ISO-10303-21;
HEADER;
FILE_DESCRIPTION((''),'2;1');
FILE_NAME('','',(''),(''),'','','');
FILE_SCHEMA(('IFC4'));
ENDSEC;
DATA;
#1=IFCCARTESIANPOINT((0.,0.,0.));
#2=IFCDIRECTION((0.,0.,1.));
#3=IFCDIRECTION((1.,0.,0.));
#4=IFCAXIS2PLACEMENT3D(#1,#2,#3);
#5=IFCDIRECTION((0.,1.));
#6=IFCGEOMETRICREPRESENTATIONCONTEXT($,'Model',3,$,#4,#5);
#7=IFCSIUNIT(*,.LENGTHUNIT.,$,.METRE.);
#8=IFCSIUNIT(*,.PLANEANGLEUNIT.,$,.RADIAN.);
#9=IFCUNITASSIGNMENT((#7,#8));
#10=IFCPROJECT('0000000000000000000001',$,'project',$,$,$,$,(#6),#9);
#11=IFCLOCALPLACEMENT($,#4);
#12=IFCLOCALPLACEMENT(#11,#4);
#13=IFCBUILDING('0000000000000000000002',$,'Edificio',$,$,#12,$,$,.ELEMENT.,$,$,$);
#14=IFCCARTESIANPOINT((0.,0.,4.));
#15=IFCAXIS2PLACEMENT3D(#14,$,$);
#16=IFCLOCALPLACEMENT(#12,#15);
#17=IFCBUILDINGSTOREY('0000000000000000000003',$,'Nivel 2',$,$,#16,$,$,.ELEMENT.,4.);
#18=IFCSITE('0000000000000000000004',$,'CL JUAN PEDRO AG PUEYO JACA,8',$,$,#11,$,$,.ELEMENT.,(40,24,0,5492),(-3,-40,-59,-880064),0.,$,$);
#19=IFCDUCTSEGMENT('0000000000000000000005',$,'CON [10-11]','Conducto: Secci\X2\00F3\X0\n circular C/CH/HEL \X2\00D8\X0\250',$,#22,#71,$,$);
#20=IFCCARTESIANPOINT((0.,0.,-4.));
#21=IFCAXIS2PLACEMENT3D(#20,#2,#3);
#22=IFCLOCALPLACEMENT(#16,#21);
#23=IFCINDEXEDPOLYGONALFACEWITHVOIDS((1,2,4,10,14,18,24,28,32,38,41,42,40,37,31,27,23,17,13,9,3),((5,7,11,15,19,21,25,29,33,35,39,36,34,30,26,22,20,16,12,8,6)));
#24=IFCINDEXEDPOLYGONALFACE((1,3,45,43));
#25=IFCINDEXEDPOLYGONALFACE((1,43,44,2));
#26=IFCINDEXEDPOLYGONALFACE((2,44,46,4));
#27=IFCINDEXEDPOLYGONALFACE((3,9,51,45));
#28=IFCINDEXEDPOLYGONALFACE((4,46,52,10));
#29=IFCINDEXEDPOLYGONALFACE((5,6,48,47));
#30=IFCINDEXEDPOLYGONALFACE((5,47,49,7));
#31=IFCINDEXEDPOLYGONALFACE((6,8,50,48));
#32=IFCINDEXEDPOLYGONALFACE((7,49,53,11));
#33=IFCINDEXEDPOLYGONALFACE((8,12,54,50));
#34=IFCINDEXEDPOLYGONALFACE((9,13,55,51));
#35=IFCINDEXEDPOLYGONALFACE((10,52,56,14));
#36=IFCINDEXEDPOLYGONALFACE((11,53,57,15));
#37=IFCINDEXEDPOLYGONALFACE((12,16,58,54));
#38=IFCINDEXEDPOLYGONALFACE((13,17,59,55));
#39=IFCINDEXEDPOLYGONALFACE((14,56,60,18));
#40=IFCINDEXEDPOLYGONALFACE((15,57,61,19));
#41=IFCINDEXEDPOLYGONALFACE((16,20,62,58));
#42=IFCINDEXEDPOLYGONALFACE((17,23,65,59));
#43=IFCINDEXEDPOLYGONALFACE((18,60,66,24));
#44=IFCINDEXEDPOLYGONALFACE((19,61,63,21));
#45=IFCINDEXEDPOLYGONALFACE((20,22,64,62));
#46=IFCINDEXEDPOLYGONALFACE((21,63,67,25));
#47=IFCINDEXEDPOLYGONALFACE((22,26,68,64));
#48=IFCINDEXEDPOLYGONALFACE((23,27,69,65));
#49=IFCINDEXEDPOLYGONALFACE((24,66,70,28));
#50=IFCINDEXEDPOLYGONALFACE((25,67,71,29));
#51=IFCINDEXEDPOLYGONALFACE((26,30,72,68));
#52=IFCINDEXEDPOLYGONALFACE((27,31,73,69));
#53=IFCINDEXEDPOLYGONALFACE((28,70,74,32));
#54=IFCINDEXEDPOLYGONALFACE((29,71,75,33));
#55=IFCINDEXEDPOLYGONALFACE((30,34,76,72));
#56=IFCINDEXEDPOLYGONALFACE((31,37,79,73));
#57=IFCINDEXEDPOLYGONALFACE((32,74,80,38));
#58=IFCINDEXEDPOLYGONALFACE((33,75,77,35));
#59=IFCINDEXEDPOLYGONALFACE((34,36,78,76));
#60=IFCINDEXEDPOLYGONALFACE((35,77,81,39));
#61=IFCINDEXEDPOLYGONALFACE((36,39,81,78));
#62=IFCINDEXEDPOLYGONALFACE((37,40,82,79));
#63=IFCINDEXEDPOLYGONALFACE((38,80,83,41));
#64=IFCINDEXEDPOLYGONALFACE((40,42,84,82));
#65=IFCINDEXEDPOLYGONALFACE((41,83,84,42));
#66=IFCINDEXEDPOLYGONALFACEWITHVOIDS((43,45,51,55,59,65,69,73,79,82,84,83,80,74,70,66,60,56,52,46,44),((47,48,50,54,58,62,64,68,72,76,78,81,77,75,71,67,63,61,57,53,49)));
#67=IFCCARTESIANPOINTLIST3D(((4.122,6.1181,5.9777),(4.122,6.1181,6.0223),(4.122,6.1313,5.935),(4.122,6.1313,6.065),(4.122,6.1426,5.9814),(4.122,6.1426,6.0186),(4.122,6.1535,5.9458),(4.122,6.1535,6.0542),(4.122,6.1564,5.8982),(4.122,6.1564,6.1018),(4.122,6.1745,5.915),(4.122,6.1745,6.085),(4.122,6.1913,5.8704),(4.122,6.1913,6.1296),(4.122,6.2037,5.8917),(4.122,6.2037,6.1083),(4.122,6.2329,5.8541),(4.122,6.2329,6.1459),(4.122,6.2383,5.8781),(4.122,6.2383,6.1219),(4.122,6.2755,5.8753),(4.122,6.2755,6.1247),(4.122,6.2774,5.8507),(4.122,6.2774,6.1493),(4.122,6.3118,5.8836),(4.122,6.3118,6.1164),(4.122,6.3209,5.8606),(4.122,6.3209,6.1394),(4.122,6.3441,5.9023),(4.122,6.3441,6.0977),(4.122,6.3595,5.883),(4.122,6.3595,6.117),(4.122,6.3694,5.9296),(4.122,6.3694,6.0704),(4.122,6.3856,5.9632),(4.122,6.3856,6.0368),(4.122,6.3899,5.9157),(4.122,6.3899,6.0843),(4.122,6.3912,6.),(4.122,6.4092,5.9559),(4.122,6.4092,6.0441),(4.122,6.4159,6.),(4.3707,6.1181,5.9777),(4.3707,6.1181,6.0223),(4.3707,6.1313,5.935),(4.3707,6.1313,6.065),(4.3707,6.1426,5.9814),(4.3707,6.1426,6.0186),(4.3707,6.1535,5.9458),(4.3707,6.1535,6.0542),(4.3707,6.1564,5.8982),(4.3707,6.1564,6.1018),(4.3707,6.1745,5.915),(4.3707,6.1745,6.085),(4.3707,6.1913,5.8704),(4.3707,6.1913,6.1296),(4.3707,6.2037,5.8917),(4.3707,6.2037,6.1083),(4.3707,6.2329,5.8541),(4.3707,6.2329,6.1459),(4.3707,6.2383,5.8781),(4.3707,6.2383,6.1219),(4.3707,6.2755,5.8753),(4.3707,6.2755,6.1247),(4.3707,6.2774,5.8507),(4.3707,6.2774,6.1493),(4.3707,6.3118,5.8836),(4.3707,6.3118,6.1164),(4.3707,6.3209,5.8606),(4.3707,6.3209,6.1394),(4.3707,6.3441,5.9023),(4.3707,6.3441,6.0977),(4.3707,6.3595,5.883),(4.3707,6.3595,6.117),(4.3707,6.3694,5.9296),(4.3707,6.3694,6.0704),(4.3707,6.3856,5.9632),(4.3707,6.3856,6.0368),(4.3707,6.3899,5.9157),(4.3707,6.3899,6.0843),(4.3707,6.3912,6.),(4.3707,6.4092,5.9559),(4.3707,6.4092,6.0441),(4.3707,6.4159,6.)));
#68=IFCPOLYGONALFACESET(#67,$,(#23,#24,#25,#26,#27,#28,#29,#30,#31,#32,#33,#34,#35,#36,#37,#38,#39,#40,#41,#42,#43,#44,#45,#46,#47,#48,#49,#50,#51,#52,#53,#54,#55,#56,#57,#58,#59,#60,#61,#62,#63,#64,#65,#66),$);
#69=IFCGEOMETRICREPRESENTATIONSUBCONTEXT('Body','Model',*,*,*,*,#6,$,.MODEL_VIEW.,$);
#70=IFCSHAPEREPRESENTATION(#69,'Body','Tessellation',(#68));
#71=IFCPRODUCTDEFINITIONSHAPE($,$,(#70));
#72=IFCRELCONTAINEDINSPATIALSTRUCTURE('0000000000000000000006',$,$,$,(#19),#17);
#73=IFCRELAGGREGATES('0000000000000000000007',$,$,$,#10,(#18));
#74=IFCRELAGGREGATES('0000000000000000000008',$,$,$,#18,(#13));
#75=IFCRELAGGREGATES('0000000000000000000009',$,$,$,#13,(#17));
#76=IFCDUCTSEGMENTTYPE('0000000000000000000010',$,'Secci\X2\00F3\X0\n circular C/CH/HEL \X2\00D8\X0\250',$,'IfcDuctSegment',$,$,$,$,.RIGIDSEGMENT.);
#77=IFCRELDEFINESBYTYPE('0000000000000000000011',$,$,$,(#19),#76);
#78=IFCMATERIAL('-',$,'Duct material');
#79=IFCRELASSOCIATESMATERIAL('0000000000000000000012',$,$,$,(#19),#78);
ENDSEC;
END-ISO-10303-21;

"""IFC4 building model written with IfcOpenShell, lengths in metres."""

from ifc_helpers import new_model, si_unit, direction, frame, origin_with_axes, origin_2d_with_axis, place, context, subcontext, project, spatial, hollow_circle, extrude, material, type_object, element, save


model = new_model("IFC4")

# Units and contexts
model_context = context("Model", 3, world=origin_with_axes(), true_north=direction((0.0, 1.0)))
body_context = subcontext(model_context, "Body", "Model", "MODEL_VIEW")
ifc_project = project(units=[si_unit("LENGTHUNIT", "METRE"), si_unit("PLANEANGLEUNIT", "RADIAN")], contexts=[model_context])

# Site, building, storey
site_placement = place(None, origin_with_axes())
site = spatial("IfcSite", under=ifc_project, at=site_placement, Name="CL JUAN PEDRO AG PUEYO JACA,8", CompositionType="ELEMENT", RefLatitude=(40, 24, 0, 5492), RefLongitude=(-3, -40, -59, -880064), RefElevation=0.0)
building_placement = place(site_placement, origin_with_axes())
building = spatial("IfcBuilding", under=site, at=building_placement, Name="Edificio", CompositionType="ELEMENT")
storey_placement = place(building_placement, frame((0.0, 0.0, 4.0)))
storey = spatial("IfcBuildingStorey", under=building, at=storey_placement, Name="Nivel 2", CompositionType="ELEMENT", Elevation=4.0)

# Duct segment
ifc_material_1 = material(Name="-", Category="Duct material")
duct_segment_type_1 = type_object("IfcDuctSegmentType", Name="Sección circular C/CH/HEL Ø250", ApplicableOccurrence="IfcDuctSegment", PredefinedType="RIGIDSEGMENT")
duct_segment_1_placement = place(storey_placement, frame((0.0, 0.0, -4.0), z_axis=(0.0, 0.0, 1.0), x_axis=(1.0, 0.0, 0.0)))
element("IfcDuctSegment", 1, at=duct_segment_1_placement, inside=storey, type_object=duct_segment_type_1, material=ifc_material_1, Name="CON [10-11]", Description="Conducto: Sección circular C/CH/HEL Ø250", context=body_context, shape_type="SweptSolid", body=[
    extrude(hollow_circle(Radius=0.1497, WallThickness=0.0247, at=origin_2d_with_axis()), frame((4.122, 6.2662, 6.0), z_axis=(1.0, 0.0, 0.0), x_axis=(0.0, 1.0, 0.0)), (0.0, 0.0, 1.0), 0.2486),
])

save(model, "model.ifc")
